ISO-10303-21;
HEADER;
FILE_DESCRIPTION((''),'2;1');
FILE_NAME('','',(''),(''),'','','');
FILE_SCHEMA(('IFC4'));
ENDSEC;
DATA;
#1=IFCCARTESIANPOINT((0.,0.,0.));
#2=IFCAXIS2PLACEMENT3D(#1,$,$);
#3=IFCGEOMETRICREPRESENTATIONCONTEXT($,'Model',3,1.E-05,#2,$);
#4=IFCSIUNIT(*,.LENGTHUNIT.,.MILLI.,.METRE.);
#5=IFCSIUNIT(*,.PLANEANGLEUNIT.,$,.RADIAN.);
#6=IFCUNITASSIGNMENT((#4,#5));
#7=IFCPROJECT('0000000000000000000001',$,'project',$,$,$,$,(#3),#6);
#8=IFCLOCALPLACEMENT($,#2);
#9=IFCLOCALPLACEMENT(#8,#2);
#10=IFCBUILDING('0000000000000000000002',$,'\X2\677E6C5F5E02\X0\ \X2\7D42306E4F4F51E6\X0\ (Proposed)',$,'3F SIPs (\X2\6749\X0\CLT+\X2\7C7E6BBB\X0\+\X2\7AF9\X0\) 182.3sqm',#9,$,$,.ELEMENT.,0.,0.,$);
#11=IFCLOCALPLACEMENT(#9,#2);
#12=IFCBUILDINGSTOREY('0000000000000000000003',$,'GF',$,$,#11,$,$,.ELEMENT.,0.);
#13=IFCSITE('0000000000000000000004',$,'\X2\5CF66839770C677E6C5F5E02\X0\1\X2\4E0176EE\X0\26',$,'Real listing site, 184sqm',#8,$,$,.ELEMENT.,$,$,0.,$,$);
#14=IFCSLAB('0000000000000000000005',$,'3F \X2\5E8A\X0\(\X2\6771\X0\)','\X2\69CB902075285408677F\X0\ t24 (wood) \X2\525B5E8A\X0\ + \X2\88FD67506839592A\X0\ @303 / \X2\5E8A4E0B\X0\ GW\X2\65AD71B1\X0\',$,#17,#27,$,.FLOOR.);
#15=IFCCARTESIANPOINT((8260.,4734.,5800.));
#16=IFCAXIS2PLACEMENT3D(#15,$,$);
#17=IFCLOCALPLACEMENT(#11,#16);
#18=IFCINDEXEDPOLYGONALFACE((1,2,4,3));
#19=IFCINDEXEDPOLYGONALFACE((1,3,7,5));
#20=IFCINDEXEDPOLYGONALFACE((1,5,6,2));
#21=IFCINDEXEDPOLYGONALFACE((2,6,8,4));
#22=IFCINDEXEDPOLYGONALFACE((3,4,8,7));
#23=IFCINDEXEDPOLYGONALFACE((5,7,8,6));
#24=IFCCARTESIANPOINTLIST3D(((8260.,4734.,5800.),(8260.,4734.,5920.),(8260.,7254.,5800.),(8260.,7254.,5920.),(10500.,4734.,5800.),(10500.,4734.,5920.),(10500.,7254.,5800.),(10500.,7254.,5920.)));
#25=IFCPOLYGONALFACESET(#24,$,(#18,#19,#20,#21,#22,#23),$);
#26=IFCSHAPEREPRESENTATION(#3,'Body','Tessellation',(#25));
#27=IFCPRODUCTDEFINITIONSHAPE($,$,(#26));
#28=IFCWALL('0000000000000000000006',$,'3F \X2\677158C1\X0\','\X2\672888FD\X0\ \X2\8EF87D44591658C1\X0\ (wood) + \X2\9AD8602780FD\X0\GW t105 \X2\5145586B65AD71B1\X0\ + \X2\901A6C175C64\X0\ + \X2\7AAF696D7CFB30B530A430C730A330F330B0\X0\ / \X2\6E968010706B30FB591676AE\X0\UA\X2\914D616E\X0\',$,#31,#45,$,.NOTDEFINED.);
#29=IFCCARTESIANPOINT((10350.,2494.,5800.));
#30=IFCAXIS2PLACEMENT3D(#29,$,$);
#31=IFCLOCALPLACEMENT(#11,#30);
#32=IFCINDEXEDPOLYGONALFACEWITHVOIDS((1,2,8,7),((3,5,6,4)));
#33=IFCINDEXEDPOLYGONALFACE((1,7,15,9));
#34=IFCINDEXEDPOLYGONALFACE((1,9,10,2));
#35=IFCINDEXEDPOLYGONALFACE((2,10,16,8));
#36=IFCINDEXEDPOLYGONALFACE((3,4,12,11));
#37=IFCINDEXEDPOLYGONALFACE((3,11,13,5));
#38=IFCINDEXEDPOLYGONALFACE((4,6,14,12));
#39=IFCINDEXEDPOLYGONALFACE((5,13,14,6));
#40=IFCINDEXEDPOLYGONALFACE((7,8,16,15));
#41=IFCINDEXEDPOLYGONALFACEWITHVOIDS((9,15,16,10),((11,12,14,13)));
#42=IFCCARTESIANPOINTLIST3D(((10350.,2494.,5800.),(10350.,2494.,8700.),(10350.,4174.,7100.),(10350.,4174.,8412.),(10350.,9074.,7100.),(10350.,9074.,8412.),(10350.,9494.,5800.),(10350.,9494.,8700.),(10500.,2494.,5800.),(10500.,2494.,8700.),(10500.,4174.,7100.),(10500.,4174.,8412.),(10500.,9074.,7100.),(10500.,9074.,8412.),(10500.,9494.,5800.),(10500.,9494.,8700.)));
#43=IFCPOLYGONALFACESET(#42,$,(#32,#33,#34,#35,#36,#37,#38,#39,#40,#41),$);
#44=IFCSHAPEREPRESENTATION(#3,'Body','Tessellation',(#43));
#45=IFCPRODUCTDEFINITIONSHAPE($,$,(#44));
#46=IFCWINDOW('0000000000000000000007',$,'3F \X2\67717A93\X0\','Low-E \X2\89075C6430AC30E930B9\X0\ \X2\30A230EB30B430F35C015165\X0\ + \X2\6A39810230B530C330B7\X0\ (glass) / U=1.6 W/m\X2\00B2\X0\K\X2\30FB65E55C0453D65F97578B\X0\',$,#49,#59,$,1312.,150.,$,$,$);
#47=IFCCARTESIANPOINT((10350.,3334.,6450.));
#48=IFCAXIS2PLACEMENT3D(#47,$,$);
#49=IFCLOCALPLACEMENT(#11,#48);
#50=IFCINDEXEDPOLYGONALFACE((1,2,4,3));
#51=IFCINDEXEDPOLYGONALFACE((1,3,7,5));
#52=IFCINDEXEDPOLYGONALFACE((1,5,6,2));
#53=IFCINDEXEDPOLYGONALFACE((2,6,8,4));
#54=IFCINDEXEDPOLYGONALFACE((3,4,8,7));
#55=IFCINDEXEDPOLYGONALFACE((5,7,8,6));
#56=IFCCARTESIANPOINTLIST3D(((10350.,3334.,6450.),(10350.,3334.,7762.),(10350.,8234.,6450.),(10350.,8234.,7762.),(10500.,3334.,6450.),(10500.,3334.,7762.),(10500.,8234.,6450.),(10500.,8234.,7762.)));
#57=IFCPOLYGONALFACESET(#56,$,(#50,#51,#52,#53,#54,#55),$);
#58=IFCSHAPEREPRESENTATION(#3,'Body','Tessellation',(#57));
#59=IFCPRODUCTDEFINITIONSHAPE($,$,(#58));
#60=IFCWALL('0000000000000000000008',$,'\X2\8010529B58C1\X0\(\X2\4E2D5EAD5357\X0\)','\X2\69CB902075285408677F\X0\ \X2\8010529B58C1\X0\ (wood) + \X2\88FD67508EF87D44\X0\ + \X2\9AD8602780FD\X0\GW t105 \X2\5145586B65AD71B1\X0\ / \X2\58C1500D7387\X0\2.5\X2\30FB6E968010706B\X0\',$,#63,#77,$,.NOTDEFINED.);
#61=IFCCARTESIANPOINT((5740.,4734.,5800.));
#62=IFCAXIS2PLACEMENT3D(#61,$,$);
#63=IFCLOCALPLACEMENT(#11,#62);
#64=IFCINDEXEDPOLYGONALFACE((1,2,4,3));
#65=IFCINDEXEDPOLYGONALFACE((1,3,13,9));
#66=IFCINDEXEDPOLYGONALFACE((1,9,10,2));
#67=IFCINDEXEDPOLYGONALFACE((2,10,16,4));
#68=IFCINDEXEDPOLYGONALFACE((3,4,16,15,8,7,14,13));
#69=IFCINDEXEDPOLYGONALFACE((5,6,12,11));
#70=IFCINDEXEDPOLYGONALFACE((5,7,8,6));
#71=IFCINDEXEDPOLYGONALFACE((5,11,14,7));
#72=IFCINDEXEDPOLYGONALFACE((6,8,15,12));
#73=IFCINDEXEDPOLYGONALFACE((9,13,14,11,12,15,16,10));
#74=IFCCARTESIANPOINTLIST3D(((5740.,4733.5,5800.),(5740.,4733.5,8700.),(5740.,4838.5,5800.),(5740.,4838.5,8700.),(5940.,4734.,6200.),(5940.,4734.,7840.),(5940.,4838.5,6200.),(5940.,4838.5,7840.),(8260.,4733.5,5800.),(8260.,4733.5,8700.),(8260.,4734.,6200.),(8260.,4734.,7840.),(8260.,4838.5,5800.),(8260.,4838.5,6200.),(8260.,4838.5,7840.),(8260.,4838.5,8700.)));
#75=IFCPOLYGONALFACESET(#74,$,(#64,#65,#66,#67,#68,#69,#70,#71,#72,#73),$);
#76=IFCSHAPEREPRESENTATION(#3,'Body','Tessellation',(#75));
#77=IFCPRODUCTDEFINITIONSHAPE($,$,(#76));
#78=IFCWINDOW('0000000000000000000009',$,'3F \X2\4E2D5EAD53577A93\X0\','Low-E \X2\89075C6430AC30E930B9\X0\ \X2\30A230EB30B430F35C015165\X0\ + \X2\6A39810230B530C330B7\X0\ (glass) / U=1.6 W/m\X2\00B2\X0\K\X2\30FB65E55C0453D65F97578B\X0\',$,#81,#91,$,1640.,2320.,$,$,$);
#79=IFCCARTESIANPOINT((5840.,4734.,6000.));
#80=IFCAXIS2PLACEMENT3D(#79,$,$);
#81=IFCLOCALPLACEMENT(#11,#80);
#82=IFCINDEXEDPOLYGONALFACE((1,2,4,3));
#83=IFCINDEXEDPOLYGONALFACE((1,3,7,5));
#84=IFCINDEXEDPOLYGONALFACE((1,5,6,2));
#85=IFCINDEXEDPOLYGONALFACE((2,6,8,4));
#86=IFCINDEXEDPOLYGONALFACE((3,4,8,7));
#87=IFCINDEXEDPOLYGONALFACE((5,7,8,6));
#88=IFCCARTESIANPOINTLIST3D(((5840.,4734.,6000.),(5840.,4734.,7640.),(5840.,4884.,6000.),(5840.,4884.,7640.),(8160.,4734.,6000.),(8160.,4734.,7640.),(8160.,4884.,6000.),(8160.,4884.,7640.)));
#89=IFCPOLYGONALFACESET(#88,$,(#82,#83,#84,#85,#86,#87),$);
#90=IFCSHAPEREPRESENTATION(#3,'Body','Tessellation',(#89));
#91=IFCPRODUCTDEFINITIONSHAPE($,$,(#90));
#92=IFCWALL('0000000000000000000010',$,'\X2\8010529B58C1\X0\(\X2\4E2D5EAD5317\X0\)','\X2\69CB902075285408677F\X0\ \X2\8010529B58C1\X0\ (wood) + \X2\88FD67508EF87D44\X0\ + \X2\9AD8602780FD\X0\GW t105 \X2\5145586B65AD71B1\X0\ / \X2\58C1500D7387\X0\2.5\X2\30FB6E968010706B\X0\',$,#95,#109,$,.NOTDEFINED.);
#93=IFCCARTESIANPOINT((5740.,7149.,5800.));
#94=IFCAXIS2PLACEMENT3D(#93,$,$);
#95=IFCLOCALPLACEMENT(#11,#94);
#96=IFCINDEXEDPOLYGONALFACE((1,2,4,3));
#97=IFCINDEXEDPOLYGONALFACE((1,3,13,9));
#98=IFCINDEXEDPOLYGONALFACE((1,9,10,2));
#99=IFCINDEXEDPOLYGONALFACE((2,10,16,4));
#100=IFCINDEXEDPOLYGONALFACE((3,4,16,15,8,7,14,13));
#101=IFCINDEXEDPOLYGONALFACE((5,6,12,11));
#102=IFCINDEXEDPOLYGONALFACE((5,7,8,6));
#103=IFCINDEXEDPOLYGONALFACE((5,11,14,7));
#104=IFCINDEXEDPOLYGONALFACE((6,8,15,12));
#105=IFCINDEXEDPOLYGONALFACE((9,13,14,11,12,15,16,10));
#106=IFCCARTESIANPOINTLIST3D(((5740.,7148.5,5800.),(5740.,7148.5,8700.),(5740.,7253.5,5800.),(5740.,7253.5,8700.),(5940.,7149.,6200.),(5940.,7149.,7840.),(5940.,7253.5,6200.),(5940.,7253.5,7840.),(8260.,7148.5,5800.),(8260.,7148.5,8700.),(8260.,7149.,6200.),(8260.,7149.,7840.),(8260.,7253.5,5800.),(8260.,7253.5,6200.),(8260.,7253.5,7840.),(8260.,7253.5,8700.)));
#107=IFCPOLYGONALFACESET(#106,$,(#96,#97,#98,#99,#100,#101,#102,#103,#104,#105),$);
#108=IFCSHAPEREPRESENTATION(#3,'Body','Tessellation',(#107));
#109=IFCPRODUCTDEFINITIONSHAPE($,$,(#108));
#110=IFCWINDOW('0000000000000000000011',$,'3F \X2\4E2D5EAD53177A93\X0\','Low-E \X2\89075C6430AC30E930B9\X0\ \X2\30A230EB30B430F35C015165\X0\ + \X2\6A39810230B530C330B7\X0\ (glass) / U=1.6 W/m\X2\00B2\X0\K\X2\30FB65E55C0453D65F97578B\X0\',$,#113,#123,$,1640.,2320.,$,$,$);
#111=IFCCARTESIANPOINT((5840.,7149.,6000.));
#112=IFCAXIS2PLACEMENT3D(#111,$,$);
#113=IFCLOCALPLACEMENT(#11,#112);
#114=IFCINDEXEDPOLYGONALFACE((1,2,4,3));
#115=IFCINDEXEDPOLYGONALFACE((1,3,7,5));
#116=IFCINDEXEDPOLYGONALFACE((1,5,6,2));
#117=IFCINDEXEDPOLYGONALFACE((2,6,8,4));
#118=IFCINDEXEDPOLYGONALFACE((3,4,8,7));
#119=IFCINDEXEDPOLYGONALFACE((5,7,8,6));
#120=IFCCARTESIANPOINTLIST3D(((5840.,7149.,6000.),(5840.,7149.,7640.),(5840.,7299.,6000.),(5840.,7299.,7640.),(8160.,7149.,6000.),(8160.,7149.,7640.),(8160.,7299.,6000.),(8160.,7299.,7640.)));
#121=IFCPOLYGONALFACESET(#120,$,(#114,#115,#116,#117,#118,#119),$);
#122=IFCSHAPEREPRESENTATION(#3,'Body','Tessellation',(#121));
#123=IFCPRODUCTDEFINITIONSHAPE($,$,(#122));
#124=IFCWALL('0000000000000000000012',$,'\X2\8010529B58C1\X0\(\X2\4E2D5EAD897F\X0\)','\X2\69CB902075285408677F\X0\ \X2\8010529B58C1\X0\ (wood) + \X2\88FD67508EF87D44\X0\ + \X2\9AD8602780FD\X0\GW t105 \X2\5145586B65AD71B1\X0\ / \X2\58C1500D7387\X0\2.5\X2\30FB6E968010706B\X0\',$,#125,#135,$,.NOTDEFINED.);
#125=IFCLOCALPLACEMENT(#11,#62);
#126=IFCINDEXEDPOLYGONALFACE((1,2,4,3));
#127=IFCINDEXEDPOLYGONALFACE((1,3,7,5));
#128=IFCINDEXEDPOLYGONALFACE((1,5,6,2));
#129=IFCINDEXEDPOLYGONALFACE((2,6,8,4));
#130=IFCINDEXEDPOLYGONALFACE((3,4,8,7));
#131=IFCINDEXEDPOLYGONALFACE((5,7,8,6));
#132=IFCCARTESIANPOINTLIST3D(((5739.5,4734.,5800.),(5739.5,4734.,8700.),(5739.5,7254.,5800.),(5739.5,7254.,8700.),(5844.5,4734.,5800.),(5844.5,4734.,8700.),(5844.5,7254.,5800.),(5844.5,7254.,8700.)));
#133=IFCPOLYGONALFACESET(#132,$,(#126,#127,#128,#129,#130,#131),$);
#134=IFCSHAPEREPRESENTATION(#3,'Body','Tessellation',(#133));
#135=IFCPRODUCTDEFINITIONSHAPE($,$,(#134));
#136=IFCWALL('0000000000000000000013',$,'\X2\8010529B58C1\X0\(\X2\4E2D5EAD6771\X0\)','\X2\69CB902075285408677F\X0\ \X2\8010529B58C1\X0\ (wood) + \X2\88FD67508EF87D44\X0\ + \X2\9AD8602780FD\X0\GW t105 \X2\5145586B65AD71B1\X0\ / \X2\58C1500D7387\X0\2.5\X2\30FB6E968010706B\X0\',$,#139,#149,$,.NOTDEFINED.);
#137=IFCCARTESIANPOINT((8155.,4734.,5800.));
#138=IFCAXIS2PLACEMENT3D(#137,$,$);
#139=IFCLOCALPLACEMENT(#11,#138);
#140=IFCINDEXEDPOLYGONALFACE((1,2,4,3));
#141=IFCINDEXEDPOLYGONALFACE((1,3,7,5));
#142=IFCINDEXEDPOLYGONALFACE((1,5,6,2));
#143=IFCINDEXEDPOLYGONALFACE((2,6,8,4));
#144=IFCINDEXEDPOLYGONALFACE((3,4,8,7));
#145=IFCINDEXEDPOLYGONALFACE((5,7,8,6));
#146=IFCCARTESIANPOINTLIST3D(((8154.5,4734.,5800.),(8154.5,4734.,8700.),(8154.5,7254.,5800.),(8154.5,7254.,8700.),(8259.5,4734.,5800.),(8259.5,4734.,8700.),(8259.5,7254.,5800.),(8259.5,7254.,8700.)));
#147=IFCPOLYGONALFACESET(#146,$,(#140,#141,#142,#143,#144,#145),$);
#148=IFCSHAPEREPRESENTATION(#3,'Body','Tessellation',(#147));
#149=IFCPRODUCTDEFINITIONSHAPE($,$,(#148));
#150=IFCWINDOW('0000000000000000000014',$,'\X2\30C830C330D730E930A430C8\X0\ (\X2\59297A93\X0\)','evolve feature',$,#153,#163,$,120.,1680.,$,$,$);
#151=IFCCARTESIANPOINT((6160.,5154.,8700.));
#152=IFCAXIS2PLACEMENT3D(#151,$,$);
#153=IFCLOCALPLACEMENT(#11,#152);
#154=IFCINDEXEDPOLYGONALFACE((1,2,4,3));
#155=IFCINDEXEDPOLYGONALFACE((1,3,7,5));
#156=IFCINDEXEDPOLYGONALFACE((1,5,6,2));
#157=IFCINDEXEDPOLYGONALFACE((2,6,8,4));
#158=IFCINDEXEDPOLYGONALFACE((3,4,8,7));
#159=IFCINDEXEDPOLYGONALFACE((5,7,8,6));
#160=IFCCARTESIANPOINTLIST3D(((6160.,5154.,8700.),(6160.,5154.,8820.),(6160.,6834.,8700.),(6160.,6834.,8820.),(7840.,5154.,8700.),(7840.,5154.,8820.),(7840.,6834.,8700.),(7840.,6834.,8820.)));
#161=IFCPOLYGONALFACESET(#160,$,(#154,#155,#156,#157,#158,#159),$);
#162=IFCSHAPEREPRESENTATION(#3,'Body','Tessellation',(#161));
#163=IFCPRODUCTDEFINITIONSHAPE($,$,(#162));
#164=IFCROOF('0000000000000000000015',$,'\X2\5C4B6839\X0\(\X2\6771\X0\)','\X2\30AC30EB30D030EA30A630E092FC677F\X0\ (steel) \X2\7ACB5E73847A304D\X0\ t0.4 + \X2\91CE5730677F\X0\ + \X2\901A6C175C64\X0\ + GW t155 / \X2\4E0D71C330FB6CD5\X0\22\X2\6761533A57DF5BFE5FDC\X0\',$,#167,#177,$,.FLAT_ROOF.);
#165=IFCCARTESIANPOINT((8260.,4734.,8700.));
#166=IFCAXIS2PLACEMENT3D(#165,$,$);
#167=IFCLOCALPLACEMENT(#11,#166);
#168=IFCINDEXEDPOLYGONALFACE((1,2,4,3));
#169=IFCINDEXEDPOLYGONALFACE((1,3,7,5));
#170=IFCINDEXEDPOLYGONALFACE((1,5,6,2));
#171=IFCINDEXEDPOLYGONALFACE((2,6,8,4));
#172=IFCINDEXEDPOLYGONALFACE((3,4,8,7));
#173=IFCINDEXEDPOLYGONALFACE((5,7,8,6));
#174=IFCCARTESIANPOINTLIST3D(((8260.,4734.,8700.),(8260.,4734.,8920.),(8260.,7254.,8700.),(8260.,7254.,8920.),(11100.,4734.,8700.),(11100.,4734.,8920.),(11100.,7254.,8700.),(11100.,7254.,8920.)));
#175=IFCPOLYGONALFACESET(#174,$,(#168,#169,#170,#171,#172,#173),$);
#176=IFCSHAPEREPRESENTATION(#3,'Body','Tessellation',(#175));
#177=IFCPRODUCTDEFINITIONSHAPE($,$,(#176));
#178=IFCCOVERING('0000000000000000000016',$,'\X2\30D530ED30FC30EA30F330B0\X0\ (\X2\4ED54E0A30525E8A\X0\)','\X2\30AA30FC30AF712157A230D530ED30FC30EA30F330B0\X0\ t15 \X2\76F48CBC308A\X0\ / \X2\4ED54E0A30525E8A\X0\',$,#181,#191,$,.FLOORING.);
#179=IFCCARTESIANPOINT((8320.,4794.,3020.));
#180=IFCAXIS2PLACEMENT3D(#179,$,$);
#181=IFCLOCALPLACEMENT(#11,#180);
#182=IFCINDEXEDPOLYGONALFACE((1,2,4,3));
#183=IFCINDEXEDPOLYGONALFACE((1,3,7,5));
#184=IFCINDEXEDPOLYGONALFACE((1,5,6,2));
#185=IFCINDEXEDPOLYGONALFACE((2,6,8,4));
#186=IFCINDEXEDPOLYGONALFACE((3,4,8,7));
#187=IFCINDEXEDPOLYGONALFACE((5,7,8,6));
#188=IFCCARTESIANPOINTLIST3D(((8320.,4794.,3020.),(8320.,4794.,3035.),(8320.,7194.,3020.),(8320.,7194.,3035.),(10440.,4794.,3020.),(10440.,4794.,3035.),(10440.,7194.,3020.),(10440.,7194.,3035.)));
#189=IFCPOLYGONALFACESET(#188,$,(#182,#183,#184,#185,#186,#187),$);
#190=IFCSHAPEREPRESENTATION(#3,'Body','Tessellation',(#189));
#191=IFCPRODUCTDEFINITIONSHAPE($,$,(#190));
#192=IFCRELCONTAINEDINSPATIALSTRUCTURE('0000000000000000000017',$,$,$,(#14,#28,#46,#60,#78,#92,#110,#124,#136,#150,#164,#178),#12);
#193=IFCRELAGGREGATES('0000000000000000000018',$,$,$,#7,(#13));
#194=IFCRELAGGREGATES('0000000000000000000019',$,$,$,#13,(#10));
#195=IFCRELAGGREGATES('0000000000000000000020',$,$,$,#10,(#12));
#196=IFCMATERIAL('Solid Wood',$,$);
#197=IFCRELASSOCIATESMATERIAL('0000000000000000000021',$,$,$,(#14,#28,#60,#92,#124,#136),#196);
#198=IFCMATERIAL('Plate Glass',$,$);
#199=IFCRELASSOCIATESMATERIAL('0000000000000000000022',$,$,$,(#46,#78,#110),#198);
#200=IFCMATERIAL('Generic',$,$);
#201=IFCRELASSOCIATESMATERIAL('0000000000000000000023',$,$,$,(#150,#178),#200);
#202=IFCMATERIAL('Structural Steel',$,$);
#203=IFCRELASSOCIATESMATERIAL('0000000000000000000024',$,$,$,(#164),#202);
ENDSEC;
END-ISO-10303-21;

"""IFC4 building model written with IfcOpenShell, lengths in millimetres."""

from ifc_helpers import new_model, si_unit, frame, frame_2d, origin, place, context, project, spatial, rectangle, extrude, material, element, fill, save


model = new_model("IFC4")

# Units and contexts
model_context = context("Model", 3, precision=1e-05, world=origin())
ifc_project = project(units=[si_unit("LENGTHUNIT", "METRE", prefix="MILLI"), si_unit("PLANEANGLEUNIT", "RADIAN")], contexts=[model_context])

# Site, building, storey
site_placement = place(None, origin())
site = spatial("IfcSite", under=ifc_project, at=site_placement, Name="島根県松江市1丁目26", ObjectType="Real listing site, 184sqm", CompositionType="ELEMENT", RefElevation=0.0)
building_placement = place(site_placement, origin())
building = spatial("IfcBuilding", under=site, at=building_placement, Name="松江市 終の住処 (Proposed)", ObjectType="3F SIPs (杉CLT+籾殻+竹) 182.3sqm", CompositionType="ELEMENT", ElevationOfRefHeight=0.0, ElevationOfTerrain=0.0)
storey_placement = place(building_placement, origin())
storey = spatial("IfcBuildingStorey", under=building, at=storey_placement, Name="GF", CompositionType="ELEMENT", Elevation=0.0)

# Slab
ifc_material_1 = material(Name="Solid Wood")
slab_placement = place(storey_placement, frame((8260.0, 4734.0, 5800.0)))
element("IfcSlab", 1, at=slab_placement, inside=storey, material=ifc_material_1, Name="3F 床(東)", Description="構造用合板 t24 (wood) 剛床 + 製材根太 @303 / 床下 GW断熱", PredefinedType="FLOOR", context=model_context, shape_type="SweptSolid", body=[
    extrude(rectangle(XDim=2240.0, YDim=2520.0, at=frame_2d((1120.0, 1260.0))), frame((8260.0, 4734.0, 5800.0)), (0.0, 0.0, 1.0), 120.0),
])

# Walls, openings, windows
wall_1_placement = place(storey_placement, frame((10350.0, 2494.0, 5800.0)))
wall_1 = element("IfcWall", 2, at=wall_1_placement, inside=storey, material=ifc_material_1, Name="3F 東壁", Description="木製 軸組外壁 (wood) + 高性能GW t105 充填断熱 + 通気層 + 窯業系サイディング / 準耐火・外皮UA配慮", PredefinedType="NOTDEFINED", context=model_context, shape_type="SweptSolid", body=[
    extrude(rectangle(XDim=150.0, YDim=7000.0, at=frame_2d((75.0, 3500.0))), frame((10350.0, 2494.0, 5800.0)), (0.0, 0.0, 1.0), 2900.0),
])
opening_1_placement = place(storey_placement, frame((10350.0, 3334.0, 6450.0)))
opening_1 = element("IfcOpeningElement", 3, at=opening_1_placement, cuts=wall_1, PredefinedType="NOTDEFINED", context=model_context, shape_type="SweptSolid", body=[
    extrude(rectangle(XDim=150.0, YDim=4900.0, at=frame_2d((75.0, 2450.0))), frame((10350.0, 3334.0, 6450.0)), (0.0, 0.0, 1.0), 1312.0),
])
ifc_material_2 = material(Name="Plate Glass")
window_1_placement = place(storey_placement, frame((10350.0, 3334.0, 6450.0)))
window_1 = element("IfcWindow", 4, at=window_1_placement, inside=storey, material=ifc_material_2, Name="3F 東窓", Description="Low-E 複層ガラス アルゴン封入 + 樹脂サッシ (glass) / U=1.6 W/m²K・日射取得型", OverallHeight=1312.0, OverallWidth=150.0, context=model_context, shape_type="SweptSolid", body=[
    extrude(rectangle(XDim=150.0, YDim=4900.0, at=frame_2d((75.0, 2450.0))), frame((10350.0, 3334.0, 6450.0)), (0.0, 0.0, 1.0), 1312.0),
])
fill(opening_1, window_1)
wall_2_placement = place(storey_placement, frame((5740.0, 4734.0, 5800.0)))
wall_2 = element("IfcWall", 5, at=wall_2_placement, inside=storey, material=ifc_material_1, Name="耐力壁(中庭南)", Description="構造用合板 耐力壁 (wood) + 製材軸組 + 高性能GW t105 充填断熱 / 壁倍率2.5・準耐火", PredefinedType="NOTDEFINED", context=model_context, shape_type="SweptSolid", body=[
    extrude(rectangle(XDim=2520.0, YDim=105.0, at=frame_2d((1260.0, 52.0))), frame((5740.0, 4734.0, 5800.0)), (0.0, 0.0, 1.0), 2900.0),
])
opening_2_placement = place(storey_placement, frame((5840.0, 4734.0, 6000.0)))
opening_2 = element("IfcOpeningElement", 6, at=opening_2_placement, cuts=wall_2, PredefinedType="NOTDEFINED", context=model_context, shape_type="SweptSolid", body=[
    extrude(rectangle(XDim=2320.0, YDim=150.0, at=frame_2d((1160.0, 75.0))), frame((5840.0, 4734.0, 6000.0)), (0.0, 0.0, 1.0), 1640.0),
])
window_2_placement = place(storey_placement, frame((5840.0, 4734.0, 6000.0)))
window_2 = element("IfcWindow", 7, at=window_2_placement, inside=storey, material=ifc_material_2, Name="3F 中庭南窓", Description="Low-E 複層ガラス アルゴン封入 + 樹脂サッシ (glass) / U=1.6 W/m²K・日射取得型", OverallHeight=1640.0, OverallWidth=2320.0, context=model_context, shape_type="SweptSolid", body=[
    extrude(rectangle(XDim=2320.0, YDim=150.0, at=frame_2d((1160.0, 75.0))), frame((5840.0, 4734.0, 6000.0)), (0.0, 0.0, 1.0), 1640.0),
])
fill(opening_2, window_2)
wall_3_placement = place(storey_placement, frame((5740.0, 7149.0, 5800.0)))
wall_3 = element("IfcWall", 8, at=wall_3_placement, inside=storey, material=ifc_material_1, Name="耐力壁(中庭北)", Description="構造用合板 耐力壁 (wood) + 製材軸組 + 高性能GW t105 充填断熱 / 壁倍率2.5・準耐火", PredefinedType="NOTDEFINED", context=model_context, shape_type="SweptSolid", body=[
    extrude(rectangle(XDim=2520.0, YDim=105.0, at=frame_2d((1260.0, 52.0))), frame((5740.0, 7149.0, 5800.0)), (0.0, 0.0, 1.0), 2900.0),
])
opening_3_placement = place(storey_placement, frame((5840.0, 7149.0, 6000.0)))
opening_3 = element("IfcOpeningElement", 9, at=opening_3_placement, cuts=wall_3, PredefinedType="NOTDEFINED", context=model_context, shape_type="SweptSolid", body=[
    extrude(rectangle(XDim=2320.0, YDim=150.0, at=frame_2d((1160.0, 75.0))), frame((5840.0, 7149.0, 6000.0)), (0.0, 0.0, 1.0), 1640.0),
])
window_3_placement = place(storey_placement, frame((5840.0, 7149.0, 6000.0)))
window_3 = element("IfcWindow", 10, at=window_3_placement, inside=storey, material=ifc_material_2, Name="3F 中庭北窓", Description="Low-E 複層ガラス アルゴン封入 + 樹脂サッシ (glass) / U=1.6 W/m²K・日射取得型", OverallHeight=1640.0, OverallWidth=2320.0, context=model_context, shape_type="SweptSolid", body=[
    extrude(rectangle(XDim=2320.0, YDim=150.0, at=frame_2d((1160.0, 75.0))), frame((5840.0, 7149.0, 6000.0)), (0.0, 0.0, 1.0), 1640.0),
])
fill(opening_3, window_3)

# Walls
wall_4_placement = place(storey_placement, frame((5740.0, 4734.0, 5800.0)))
element("IfcWall", 11, at=wall_4_placement, inside=storey, material=ifc_material_1, Name="耐力壁(中庭西)", Description="構造用合板 耐力壁 (wood) + 製材軸組 + 高性能GW t105 充填断熱 / 壁倍率2.5・準耐火", PredefinedType="NOTDEFINED", context=model_context, shape_type="SweptSolid", body=[
    extrude(rectangle(XDim=105.0, YDim=2520.0, at=frame_2d((52.0, 1260.0))), frame((5740.0, 4734.0, 5800.0)), (0.0, 0.0, 1.0), 2900.0),
])
wall_5_placement = place(storey_placement, frame((8155.0, 4734.0, 5800.0)))
element("IfcWall", 12, at=wall_5_placement, inside=storey, material=ifc_material_1, Name="耐力壁(中庭東)", Description="構造用合板 耐力壁 (wood) + 製材軸組 + 高性能GW t105 充填断熱 / 壁倍率2.5・準耐火", PredefinedType="NOTDEFINED", context=model_context, shape_type="SweptSolid", body=[
    extrude(rectangle(XDim=105.0, YDim=2520.0, at=frame_2d((52.0, 1260.0))), frame((8155.0, 4734.0, 5800.0)), (0.0, 0.0, 1.0), 2900.0),
])

# Window
ifc_material_3 = material(Name="Generic")
window_4_placement = place(storey_placement, frame((6160.0, 5154.0, 8700.0)))
element("IfcWindow", 13, at=window_4_placement, inside=storey, material=ifc_material_3, Name="トップライト (天窓)", Description="evolve feature", OverallHeight=120.0, OverallWidth=1680.0, context=model_context, shape_type="SweptSolid", body=[
    extrude(rectangle(XDim=1680.0, YDim=1680.0, at=frame_2d((840.0, 840.0))), frame((6160.0, 5154.0, 8700.0)), (0.0, 0.0, 1.0), 120.0),
])

# Roof
ifc_material_4 = material(Name="Structural Steel")
for number, where, name in (
    (14, (8260.0, 4734.0, 8700.0), "屋根(東)"),
):
    element("IfcRoof", number, at=place(storey_placement, frame(where)), inside=storey, material=ifc_material_4, Name=name, Description="ガルバリウム鋼板 (steel) 立平葺き t0.4 + 野地板 + 通気層 + GW t155 / 不燃・法22条区域対応", PredefinedType="FLAT_ROOF", context=model_context, shape_type="SweptSolid", body=[
        extrude(rectangle(XDim=2840.0, YDim=2520.0, at=frame_2d((1420.0, 1260.0))), frame((8260.0, 4734.0, 8700.0)), (0.0, 0.0, 1.0), 220.0),
    ])

# Covering
covering_1_placement = place(storey_placement, frame((8320.0, 4794.0, 3020.0)))
element("IfcCovering", 15, at=covering_1_placement, inside=storey, material=ifc_material_3, Name="フローリング (仕上げ床)", Description="オーク無垢フローリング t15 直貼り / 仕上げ床", PredefinedType="FLOORING", context=model_context, shape_type="SweptSolid", body=[
    extrude(rectangle(XDim=2120.0, YDim=2400.0, at=frame_2d((1060.0, 1200.0))), frame((8320.0, 4794.0, 3020.0)), (0.0, 0.0, 1.0), 15.0),
])

save(model, "model.ifc")
